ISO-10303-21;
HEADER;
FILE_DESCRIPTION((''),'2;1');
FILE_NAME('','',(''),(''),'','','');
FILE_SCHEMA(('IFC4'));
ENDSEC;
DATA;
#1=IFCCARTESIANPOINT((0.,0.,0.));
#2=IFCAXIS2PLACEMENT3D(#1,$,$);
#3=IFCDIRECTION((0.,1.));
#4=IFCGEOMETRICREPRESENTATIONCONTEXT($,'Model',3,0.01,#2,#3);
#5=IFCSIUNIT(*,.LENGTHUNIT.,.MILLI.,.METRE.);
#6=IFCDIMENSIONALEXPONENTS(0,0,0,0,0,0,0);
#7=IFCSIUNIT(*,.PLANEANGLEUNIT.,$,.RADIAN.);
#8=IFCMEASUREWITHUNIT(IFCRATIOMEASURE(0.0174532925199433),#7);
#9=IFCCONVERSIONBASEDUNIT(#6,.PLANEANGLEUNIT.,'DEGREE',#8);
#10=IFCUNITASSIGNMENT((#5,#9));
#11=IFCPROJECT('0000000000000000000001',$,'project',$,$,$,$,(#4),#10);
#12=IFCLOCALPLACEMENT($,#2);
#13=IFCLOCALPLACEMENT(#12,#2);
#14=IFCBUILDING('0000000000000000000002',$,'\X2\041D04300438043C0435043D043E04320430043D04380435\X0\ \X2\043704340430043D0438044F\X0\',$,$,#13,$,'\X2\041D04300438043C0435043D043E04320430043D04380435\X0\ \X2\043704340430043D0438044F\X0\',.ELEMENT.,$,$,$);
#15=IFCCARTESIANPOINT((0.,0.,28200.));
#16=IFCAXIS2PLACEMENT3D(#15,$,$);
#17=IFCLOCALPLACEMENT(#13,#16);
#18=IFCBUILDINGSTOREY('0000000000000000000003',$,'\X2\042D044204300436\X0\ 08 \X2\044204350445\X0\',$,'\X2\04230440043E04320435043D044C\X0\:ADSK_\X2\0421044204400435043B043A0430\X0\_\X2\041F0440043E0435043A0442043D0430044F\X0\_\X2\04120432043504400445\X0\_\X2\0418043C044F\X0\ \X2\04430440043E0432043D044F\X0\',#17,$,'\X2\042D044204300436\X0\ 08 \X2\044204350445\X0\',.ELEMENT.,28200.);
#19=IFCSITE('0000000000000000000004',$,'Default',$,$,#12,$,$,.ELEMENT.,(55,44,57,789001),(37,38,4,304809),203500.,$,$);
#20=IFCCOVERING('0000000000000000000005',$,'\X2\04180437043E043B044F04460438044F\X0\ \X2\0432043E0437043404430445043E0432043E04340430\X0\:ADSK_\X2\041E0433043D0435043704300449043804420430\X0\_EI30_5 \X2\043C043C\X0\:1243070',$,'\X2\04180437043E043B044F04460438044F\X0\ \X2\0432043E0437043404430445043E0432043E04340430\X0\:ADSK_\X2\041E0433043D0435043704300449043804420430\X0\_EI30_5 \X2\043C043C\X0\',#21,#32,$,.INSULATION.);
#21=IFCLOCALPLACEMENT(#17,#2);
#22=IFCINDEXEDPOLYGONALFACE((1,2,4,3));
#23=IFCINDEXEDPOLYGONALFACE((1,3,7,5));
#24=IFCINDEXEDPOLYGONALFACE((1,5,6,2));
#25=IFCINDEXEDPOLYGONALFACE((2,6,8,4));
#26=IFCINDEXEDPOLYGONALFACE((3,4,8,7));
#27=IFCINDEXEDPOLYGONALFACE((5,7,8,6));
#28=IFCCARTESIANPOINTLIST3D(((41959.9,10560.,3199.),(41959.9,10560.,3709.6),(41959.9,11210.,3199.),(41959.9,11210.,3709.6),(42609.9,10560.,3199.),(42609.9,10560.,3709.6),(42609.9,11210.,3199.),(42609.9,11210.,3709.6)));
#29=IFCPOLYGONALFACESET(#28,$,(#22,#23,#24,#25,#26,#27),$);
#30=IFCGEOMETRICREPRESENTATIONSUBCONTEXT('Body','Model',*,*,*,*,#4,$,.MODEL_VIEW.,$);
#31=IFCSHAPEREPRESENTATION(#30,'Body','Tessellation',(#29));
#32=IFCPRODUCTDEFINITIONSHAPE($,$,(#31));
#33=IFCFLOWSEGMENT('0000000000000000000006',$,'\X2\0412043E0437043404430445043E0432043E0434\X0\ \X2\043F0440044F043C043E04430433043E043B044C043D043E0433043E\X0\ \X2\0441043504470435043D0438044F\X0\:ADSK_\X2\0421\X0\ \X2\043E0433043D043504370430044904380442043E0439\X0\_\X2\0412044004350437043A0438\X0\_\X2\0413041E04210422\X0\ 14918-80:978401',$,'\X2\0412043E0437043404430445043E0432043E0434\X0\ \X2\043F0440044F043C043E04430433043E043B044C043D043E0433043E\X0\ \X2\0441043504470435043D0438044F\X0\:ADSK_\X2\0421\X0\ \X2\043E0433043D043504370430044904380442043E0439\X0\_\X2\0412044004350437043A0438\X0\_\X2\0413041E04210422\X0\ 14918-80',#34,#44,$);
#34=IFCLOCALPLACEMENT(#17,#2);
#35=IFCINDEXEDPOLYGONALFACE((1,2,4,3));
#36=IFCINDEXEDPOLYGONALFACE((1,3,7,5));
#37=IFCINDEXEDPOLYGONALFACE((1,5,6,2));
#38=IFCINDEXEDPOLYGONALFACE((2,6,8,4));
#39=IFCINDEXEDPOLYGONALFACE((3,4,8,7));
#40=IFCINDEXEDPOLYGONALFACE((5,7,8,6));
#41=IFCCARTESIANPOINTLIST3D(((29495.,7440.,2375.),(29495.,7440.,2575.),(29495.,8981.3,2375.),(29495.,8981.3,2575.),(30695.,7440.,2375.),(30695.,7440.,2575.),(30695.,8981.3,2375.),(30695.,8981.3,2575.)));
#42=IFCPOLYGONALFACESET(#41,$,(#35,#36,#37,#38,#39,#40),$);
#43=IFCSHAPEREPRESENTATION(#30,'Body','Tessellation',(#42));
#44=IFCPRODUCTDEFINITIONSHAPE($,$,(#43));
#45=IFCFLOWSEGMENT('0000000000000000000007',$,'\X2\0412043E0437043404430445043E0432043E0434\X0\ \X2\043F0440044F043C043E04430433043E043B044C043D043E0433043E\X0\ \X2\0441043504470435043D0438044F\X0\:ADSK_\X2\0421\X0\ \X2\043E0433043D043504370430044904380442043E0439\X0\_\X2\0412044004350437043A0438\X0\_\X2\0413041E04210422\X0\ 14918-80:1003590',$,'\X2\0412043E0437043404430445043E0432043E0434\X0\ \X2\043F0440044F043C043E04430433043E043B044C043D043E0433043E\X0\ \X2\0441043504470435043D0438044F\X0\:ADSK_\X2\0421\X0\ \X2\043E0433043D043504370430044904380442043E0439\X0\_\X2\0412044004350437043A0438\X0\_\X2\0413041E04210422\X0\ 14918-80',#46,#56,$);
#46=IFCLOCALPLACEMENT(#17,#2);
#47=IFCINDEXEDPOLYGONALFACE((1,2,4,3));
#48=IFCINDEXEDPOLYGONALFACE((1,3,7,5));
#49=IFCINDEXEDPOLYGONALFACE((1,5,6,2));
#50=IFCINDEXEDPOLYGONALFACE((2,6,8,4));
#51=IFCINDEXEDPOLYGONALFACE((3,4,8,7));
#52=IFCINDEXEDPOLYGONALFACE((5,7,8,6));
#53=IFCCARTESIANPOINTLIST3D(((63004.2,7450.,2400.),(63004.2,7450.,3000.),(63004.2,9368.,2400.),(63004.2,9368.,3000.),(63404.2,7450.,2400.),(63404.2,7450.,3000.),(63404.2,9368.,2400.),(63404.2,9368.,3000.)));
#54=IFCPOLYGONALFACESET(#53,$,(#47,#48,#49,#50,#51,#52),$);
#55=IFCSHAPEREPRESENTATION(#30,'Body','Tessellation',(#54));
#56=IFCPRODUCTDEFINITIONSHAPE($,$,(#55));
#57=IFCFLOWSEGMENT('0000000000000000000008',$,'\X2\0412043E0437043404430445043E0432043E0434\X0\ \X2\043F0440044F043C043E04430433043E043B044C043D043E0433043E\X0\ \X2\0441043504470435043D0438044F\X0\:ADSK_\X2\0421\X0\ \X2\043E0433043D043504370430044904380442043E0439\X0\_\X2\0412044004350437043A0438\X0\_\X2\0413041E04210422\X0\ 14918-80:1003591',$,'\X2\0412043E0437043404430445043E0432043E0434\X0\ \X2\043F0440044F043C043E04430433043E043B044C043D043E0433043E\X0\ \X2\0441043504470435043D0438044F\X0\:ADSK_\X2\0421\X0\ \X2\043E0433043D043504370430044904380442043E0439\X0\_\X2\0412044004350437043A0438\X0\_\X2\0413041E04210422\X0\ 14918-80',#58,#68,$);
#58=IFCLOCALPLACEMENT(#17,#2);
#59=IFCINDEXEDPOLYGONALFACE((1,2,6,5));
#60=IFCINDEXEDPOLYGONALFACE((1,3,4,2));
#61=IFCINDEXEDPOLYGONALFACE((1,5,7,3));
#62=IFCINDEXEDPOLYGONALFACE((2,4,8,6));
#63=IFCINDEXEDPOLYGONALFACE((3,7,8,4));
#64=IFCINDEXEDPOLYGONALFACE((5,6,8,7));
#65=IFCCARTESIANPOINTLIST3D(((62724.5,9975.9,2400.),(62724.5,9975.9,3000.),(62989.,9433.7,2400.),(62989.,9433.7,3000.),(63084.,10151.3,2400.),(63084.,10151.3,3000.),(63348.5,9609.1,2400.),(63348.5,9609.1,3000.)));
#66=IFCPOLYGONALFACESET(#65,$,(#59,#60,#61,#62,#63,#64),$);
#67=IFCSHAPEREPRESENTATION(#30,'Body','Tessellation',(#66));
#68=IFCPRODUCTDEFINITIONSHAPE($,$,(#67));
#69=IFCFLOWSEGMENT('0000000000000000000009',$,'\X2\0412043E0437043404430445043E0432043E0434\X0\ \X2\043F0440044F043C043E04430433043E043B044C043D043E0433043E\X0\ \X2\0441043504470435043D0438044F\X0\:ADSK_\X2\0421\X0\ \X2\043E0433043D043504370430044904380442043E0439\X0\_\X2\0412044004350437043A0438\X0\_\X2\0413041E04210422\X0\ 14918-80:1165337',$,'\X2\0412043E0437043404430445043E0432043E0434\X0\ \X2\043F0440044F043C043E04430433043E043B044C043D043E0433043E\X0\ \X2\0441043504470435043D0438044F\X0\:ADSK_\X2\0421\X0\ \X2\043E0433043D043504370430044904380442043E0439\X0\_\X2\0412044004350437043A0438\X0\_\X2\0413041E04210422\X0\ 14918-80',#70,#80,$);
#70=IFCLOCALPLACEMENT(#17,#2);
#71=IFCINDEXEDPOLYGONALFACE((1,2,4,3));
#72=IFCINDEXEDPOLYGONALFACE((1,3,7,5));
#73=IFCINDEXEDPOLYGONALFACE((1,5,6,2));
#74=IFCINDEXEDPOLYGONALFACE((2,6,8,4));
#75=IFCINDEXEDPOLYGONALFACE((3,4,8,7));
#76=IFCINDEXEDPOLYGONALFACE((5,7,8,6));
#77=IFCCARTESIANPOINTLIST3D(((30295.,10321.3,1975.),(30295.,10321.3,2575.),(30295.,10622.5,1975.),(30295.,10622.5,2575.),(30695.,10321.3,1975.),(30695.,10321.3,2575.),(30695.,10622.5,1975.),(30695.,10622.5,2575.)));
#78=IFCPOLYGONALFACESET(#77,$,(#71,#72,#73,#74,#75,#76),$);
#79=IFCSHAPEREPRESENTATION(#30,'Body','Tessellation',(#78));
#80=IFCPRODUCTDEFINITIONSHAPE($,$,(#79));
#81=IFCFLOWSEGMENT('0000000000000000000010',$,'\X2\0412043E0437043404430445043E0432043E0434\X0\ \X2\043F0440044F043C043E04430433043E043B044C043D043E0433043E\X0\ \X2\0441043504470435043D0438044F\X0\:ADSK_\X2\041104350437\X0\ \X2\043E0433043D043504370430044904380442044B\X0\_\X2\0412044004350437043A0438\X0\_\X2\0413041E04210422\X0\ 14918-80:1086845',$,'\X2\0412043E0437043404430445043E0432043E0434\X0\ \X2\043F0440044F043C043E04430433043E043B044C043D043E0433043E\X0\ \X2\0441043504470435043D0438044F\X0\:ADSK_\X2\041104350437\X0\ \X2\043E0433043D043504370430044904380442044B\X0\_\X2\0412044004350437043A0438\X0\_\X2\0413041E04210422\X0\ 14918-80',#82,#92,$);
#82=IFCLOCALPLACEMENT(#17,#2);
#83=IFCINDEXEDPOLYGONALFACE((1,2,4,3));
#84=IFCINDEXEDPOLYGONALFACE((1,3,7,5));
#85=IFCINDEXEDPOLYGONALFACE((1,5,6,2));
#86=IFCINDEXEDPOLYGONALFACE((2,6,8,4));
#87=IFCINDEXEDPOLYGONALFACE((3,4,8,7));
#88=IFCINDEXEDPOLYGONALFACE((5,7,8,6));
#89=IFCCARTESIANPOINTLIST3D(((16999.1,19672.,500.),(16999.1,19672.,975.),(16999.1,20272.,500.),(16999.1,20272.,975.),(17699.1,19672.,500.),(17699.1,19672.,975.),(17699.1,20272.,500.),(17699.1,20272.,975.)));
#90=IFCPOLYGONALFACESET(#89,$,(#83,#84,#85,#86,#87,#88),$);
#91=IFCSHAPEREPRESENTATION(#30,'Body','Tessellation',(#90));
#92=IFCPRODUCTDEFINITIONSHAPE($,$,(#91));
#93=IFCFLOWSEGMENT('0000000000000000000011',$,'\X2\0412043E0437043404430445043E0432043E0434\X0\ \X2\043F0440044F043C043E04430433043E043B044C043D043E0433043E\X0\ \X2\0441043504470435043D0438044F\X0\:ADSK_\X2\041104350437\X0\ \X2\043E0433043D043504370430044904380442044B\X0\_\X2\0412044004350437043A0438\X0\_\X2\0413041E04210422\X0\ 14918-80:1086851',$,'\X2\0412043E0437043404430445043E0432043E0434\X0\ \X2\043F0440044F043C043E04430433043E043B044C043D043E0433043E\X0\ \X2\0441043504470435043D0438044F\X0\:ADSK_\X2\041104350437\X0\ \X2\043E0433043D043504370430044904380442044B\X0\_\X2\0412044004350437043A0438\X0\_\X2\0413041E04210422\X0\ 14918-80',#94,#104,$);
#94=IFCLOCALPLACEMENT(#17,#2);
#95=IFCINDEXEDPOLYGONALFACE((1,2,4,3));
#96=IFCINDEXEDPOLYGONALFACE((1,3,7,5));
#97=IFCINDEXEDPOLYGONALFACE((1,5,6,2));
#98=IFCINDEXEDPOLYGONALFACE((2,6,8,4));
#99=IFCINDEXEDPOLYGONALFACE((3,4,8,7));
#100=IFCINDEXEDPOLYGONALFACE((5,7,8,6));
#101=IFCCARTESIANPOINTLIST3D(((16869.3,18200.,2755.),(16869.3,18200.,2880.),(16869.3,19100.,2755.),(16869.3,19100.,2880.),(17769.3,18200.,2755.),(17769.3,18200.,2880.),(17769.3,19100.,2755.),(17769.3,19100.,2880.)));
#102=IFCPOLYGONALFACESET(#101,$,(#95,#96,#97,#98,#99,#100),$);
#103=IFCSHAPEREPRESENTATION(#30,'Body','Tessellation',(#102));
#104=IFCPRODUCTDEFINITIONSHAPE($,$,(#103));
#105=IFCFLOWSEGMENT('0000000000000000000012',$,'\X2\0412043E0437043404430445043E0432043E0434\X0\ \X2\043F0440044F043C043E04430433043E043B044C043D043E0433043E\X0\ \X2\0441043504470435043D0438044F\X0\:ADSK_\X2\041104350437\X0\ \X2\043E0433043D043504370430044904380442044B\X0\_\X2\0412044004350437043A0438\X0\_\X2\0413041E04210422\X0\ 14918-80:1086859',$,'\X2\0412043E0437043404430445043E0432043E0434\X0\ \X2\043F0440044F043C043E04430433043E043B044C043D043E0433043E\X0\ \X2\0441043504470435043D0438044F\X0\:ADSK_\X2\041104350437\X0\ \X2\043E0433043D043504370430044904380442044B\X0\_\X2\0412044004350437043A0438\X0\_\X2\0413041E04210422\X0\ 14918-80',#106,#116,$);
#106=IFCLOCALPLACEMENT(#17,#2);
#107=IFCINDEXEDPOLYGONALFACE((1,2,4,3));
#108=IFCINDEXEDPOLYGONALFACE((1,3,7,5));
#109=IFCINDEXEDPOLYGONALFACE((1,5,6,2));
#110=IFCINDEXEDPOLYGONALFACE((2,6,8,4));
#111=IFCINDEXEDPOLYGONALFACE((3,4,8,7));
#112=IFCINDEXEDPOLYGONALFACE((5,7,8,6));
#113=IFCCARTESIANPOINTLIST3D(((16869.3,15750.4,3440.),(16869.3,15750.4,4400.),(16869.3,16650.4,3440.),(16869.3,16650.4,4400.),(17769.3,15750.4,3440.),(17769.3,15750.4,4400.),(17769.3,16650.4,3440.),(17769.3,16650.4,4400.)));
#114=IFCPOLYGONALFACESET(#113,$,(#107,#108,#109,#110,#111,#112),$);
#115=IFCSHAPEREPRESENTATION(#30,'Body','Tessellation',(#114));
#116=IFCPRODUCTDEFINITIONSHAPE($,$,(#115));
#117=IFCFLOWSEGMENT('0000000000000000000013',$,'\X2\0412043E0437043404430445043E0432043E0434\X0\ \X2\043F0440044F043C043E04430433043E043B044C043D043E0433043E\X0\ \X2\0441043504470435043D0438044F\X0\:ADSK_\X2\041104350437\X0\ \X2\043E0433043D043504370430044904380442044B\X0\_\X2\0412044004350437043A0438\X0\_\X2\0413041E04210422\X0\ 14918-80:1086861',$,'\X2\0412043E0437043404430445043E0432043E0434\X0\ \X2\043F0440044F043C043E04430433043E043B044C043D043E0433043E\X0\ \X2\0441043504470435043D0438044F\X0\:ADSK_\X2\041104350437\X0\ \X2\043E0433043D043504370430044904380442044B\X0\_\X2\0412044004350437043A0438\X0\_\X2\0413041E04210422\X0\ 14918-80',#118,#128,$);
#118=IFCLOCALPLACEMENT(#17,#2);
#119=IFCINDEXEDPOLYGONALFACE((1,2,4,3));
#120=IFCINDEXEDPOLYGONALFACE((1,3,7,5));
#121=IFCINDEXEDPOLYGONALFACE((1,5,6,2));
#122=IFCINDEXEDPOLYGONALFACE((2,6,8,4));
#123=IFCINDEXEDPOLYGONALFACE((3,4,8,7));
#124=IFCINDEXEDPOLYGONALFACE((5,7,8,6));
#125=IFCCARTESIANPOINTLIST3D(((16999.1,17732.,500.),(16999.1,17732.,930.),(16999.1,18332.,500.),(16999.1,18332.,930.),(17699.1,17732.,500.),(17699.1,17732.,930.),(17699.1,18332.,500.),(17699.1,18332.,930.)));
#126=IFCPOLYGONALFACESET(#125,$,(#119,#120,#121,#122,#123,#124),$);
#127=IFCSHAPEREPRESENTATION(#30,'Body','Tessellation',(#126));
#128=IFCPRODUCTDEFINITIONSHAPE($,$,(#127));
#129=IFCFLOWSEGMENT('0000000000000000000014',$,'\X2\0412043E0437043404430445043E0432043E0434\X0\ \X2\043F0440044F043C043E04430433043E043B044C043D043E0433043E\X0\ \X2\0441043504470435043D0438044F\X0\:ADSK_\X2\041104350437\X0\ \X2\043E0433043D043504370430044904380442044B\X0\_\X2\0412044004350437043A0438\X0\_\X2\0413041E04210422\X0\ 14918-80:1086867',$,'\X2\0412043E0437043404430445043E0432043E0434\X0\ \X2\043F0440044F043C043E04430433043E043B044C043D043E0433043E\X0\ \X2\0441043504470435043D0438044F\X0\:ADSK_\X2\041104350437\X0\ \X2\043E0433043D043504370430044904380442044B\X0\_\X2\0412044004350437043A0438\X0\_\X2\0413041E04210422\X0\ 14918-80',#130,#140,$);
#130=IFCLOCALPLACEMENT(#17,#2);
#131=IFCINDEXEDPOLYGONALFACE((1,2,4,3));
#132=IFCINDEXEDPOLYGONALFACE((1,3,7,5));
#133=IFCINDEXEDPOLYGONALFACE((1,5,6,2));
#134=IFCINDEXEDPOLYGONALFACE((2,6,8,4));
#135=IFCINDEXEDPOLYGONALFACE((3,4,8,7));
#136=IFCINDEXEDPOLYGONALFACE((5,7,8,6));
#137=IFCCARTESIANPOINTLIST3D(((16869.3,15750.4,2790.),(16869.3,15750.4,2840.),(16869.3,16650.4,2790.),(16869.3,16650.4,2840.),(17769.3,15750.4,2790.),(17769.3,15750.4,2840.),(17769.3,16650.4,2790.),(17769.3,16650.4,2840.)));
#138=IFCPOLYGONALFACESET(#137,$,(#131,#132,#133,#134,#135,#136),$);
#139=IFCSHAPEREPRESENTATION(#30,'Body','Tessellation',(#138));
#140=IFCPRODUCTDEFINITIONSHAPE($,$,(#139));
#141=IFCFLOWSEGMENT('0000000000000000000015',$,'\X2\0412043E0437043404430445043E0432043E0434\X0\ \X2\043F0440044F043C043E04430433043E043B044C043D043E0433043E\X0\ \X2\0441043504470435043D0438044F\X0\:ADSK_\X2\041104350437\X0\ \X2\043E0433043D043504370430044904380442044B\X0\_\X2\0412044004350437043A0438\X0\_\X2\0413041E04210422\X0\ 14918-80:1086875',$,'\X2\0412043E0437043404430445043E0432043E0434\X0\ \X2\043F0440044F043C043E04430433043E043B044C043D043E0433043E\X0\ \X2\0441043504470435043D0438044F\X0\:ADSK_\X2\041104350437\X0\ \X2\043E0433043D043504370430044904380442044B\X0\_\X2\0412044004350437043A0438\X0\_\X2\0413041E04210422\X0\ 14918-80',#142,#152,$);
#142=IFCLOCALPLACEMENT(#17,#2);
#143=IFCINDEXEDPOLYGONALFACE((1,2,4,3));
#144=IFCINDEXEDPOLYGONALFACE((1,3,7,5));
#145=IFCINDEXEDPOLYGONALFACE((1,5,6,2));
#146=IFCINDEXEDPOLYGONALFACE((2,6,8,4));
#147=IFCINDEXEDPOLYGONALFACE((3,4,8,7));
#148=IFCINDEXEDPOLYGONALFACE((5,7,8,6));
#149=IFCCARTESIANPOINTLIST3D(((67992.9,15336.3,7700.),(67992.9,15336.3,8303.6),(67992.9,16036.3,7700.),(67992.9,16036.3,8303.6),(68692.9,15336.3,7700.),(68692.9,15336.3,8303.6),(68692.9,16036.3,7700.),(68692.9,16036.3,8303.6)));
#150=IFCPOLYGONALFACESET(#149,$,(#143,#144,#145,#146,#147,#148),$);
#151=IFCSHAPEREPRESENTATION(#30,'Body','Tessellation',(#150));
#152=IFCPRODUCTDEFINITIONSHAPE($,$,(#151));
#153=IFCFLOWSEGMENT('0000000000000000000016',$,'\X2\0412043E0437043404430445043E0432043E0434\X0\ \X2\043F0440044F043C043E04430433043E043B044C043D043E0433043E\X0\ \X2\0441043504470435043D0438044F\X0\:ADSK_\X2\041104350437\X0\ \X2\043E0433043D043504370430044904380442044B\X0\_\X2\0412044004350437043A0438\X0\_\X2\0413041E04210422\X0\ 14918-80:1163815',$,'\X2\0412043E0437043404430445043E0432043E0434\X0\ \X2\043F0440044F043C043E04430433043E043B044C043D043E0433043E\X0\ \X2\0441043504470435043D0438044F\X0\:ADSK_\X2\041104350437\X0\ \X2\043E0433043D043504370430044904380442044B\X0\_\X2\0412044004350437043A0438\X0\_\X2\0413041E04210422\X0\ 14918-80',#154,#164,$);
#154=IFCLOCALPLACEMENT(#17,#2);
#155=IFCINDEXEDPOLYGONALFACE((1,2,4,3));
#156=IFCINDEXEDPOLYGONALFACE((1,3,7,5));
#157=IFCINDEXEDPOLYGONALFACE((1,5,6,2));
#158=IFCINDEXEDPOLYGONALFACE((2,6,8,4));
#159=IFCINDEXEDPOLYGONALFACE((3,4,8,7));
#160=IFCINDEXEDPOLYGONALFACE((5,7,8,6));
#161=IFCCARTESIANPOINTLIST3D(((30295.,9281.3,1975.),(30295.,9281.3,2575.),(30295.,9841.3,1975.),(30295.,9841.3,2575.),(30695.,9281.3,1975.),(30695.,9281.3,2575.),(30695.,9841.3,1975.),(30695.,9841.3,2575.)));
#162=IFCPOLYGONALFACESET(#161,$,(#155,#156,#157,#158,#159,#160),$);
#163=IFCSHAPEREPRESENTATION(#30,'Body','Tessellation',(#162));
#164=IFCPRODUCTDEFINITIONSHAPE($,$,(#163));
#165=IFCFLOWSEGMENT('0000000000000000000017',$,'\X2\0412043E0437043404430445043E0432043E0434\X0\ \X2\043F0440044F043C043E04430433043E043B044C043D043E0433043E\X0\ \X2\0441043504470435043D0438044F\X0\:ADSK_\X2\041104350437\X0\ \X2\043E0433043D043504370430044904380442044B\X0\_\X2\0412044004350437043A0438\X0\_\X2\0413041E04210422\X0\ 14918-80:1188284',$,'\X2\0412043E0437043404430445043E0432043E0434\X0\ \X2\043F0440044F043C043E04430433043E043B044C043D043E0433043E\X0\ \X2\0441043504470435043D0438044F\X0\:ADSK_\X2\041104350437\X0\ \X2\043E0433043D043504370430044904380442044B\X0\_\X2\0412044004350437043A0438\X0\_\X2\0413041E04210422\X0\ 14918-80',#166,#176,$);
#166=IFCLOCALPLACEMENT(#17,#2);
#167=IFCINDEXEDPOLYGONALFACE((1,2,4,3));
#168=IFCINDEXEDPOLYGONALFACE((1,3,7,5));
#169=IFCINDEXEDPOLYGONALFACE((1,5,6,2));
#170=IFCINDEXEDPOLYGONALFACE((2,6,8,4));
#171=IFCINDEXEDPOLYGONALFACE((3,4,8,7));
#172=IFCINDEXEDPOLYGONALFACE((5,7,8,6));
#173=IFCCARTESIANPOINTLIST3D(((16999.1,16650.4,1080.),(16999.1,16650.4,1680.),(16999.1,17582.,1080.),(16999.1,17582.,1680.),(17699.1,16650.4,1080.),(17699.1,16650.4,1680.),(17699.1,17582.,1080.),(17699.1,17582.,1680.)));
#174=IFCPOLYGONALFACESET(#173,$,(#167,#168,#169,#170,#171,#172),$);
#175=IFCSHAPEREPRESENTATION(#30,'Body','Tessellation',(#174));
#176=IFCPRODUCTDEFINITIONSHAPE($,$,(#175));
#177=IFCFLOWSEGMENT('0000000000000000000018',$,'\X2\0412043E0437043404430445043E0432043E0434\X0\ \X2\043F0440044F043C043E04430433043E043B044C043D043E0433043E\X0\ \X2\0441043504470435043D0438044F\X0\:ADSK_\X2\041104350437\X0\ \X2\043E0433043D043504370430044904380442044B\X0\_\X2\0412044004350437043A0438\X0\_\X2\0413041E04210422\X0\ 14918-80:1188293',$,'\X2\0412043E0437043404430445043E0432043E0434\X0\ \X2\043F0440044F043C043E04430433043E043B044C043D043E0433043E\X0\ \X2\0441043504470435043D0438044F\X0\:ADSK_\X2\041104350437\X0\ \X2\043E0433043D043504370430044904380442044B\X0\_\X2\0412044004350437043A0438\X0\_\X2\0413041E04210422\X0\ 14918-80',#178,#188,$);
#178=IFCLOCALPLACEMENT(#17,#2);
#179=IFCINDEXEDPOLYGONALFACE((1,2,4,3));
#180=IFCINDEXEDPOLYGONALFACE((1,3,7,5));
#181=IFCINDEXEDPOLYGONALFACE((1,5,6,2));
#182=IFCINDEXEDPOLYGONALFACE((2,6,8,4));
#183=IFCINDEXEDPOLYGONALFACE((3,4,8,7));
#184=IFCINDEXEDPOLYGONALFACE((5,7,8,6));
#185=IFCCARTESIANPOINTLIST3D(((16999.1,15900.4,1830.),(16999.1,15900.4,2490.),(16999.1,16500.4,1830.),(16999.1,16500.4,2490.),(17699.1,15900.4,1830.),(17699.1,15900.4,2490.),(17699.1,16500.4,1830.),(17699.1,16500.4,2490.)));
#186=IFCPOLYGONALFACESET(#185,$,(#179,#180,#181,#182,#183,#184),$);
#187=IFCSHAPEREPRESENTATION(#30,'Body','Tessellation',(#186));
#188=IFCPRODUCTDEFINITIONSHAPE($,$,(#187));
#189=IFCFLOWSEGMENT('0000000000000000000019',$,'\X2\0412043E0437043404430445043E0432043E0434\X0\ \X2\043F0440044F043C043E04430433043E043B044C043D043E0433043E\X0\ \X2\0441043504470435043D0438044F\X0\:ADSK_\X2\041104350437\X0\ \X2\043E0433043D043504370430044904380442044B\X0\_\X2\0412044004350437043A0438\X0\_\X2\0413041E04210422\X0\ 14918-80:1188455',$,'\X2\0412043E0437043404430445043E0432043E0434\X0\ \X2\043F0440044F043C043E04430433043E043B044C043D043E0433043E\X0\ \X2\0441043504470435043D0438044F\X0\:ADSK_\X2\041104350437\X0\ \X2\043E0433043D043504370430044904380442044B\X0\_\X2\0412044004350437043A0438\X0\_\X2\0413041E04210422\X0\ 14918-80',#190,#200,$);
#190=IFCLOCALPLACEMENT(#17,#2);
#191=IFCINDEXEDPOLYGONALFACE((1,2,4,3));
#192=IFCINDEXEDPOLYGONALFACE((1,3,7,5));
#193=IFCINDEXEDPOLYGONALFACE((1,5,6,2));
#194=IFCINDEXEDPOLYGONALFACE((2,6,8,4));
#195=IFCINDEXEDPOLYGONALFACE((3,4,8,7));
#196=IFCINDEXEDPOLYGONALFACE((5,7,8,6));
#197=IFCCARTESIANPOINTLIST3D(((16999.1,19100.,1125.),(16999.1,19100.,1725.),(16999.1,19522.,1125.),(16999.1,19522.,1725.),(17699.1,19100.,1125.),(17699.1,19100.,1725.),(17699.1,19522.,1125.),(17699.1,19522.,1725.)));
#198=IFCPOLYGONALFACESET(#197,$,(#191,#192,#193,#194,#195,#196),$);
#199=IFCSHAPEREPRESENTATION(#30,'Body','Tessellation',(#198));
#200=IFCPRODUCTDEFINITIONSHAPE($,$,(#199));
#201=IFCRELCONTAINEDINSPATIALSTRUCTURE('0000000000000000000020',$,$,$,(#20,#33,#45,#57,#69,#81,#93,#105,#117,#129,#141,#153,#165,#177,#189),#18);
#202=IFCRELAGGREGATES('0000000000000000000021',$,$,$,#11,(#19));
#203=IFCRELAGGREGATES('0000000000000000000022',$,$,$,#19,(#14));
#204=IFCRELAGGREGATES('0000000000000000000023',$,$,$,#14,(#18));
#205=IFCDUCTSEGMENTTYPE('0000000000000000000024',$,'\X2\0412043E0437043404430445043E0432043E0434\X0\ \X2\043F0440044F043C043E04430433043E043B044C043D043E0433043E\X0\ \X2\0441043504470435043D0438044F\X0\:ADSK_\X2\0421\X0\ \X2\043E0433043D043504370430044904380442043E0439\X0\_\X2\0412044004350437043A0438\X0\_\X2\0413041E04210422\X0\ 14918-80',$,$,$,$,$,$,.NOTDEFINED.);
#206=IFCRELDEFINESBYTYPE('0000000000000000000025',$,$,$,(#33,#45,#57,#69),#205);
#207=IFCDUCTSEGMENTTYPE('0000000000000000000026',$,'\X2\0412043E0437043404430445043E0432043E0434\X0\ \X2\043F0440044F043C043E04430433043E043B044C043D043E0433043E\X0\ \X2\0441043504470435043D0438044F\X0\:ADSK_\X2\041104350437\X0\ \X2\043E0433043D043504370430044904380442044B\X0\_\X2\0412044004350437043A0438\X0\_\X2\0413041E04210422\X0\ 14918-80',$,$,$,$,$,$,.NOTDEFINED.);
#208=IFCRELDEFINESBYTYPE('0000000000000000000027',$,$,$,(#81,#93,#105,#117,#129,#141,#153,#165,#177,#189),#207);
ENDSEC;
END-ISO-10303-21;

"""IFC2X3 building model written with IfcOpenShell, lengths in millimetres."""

from ifc_helpers import new_model, entity, si_unit, converted_unit, direction, frame, origin, origin_2d_with_axis, place, context, subcontext, project, spatial, rectangle, extrude, type_object, element, save


model = new_model("IFC2X3")

# Units and contexts
model_context = context("Model", 3, precision=0.01, world=origin(), true_north=direction((0.0, 1.0)))
body_context = subcontext(model_context, "Body", "Model", "MODEL_VIEW")
ifc_project = project(units=[si_unit("LENGTHUNIT", "METRE", prefix="MILLI"), converted_unit("PLANEANGLEUNIT", "DEGREE", entity("IfcRatioMeasure", 0.0174532925199433), si_unit("PLANEANGLEUNIT", "RADIAN"), dimensions=[0, 0, 0, 0, 0, 0, 0])], contexts=[model_context])

# Site, building, storey
site_placement = place(None, origin())
site = spatial("IfcSite", under=ifc_project, at=site_placement, Name="Default", CompositionType="ELEMENT", RefLatitude=(55, 44, 57, 789001), RefLongitude=(37, 38, 4, 304809), RefElevation=203500.0)
building_placement = place(site_placement, origin())
building = spatial("IfcBuilding", under=site, at=building_placement, Name="Наименование здания", LongName="Наименование здания", CompositionType="ELEMENT")
storey_placement = place(building_placement, frame((0.0, 0.0, 28200.0)))
storey = spatial("IfcBuildingStorey", under=building, at=storey_placement, Name="Этаж 08 тех", ObjectType="Уровень:ADSK_Стрелка_Проектная_Вверх_Имя уровня", LongName="Этаж 08 тех", CompositionType="ELEMENT", Elevation=28200.0)

# Covering
covering_1_placement = place(storey_placement, frame((41959.9, 10560.0, 3199.0)))
element("IfcCovering", 1, at=covering_1_placement, inside=storey, Name="Изоляция воздуховода:ADSK_Огнезащита_EI30_5 мм:1243070", ObjectType="Изоляция воздуховода:ADSK_Огнезащита_EI30_5 мм", PredefinedType="INSULATION", context=body_context, shape_type="SweptSolid", body=[
    extrude(rectangle(XDim=650.0, YDim=650.0, at=origin_2d_with_axis()), frame((325.0, 325.0, 0.0), z_axis=(0.0, 0.0, 1.0), x_axis=(-1.0, 0.0, 0.0)), (0.0, 0.0, 1.0), 510.6),
])

# Flow segments
duct_segment_type_1 = type_object("IfcDuctSegmentType", Name="Воздуховод прямоугольного сечения:ADSK_С огнезащитой_Врезки_ГОСТ 14918-80", PredefinedType="NOTDEFINED")
flow_segment_1_placement = place(storey_placement, frame((29495.0, 7440.0, 2375.0)))
element("IfcFlowSegment", 2, at=flow_segment_1_placement, inside=storey, type_object=duct_segment_type_1, Name="Воздуховод прямоугольного сечения:ADSK_С огнезащитой_Врезки_ГОСТ 14918-80:978401", ObjectType="Воздуховод прямоугольного сечения:ADSK_С огнезащитой_Врезки_ГОСТ 14918-80", context=body_context, shape_type="SweptSolid", body=[
    extrude(rectangle(XDim=1541.3, YDim=1200.0, at=origin_2d_with_axis()), frame((600.0, 770.6, 0.0), z_axis=(0.0, 0.0, 1.0), x_axis=(0.0, 1.0, 0.0)), (0.0, 0.0, 1.0), 200.0),
])
flow_segment_2_placement = place(storey_placement, frame((63004.2, 7450.0, 2400.0)))
element("IfcFlowSegment", 3, at=flow_segment_2_placement, inside=storey, type_object=duct_segment_type_1, Name="Воздуховод прямоугольного сечения:ADSK_С огнезащитой_Врезки_ГОСТ 14918-80:1003590", ObjectType="Воздуховод прямоугольного сечения:ADSK_С огнезащитой_Врезки_ГОСТ 14918-80", context=body_context, shape_type="SweptSolid", body=[
    extrude(rectangle(XDim=1918.0, YDim=400.0, at=origin_2d_with_axis()), frame((200.0, 959.0, 0.0), z_axis=(0.0, 0.0, 1.0), x_axis=(0.0, -1.0, 0.0)), (0.0, 0.0, 1.0), 600.0),
])
flow_segment_3_placement = place(storey_placement, frame((62724.5, 9433.7, 2400.0)))
element("IfcFlowSegment", 4, at=flow_segment_3_placement, inside=storey, type_object=duct_segment_type_1, Name="Воздуховод прямоугольного сечения:ADSK_С огнезащитой_Врезки_ГОСТ 14918-80:1003591", ObjectType="Воздуховод прямоугольного сечения:ADSK_С огнезащитой_Врезки_ГОСТ 14918-80", context=body_context, shape_type="SweptSolid", body=[
    extrude(rectangle(XDim=603.3, YDim=400.0, at=origin_2d_with_axis()), frame((312.0, 358.8, 0.0), z_axis=(0.0, 0.0, 1.0), x_axis=(-0.438371, 0.898794, 0.0)), (0.0, 0.0, 1.0), 600.0),
])
flow_segment_4_placement = place(storey_placement, frame((30295.0, 10321.3, 1975.0)))
element("IfcFlowSegment", 5, at=flow_segment_4_placement, inside=storey, type_object=duct_segment_type_1, Name="Воздуховод прямоугольного сечения:ADSK_С огнезащитой_Врезки_ГОСТ 14918-80:1165337", ObjectType="Воздуховод прямоугольного сечения:ADSK_С огнезащитой_Врезки_ГОСТ 14918-80", context=body_context, shape_type="SweptSolid", body=[
    extrude(rectangle(XDim=301.2, YDim=400.0, at=origin_2d_with_axis()), frame((200.0, 150.6, 0.0), z_axis=(0.0, 0.0, 1.0), x_axis=(0.0, 1.0, 0.0)), (0.0, 0.0, 1.0), 600.0),
])
duct_segment_type_2 = type_object("IfcDuctSegmentType", Name="Воздуховод прямоугольного сечения:ADSK_Без огнезащиты_Врезки_ГОСТ 14918-80", PredefinedType="NOTDEFINED")
flow_segment_5_placement = place(storey_placement, frame((16999.1, 19672.0, 500.0)))
element("IfcFlowSegment", 6, at=flow_segment_5_placement, inside=storey, type_object=duct_segment_type_2, Name="Воздуховод прямоугольного сечения:ADSK_Без огнезащиты_Врезки_ГОСТ 14918-80:1086845", ObjectType="Воздуховод прямоугольного сечения:ADSK_Без огнезащиты_Врезки_ГОСТ 14918-80", context=body_context, shape_type="SweptSolid", body=[
    extrude(rectangle(XDim=700.0, YDim=600.0, at=origin_2d_with_axis()), frame((350.0, 300.0, 0.0), z_axis=(0.0, 0.0, 1.0), x_axis=(-1.0, 0.0, 0.0)), (0.0, 0.0, 1.0), 475.0),
])
flow_segment_6_placement = place(storey_placement, frame((16869.3, 18200.0, 2755.0)))
element("IfcFlowSegment", 7, at=flow_segment_6_placement, inside=storey, type_object=duct_segment_type_2, Name="Воздуховод прямоугольного сечения:ADSK_Без огнезащиты_Врезки_ГОСТ 14918-80:1086851", ObjectType="Воздуховод прямоугольного сечения:ADSK_Без огнезащиты_Врезки_ГОСТ 14918-80", context=body_context, shape_type="SweptSolid", body=[
    extrude(rectangle(XDim=900.0, YDim=900.0, at=origin_2d_with_axis()), frame((450.0, 450.0, 0.0)), (0.0, 0.0, 1.0), 125.0),
])
flow_segment_7_placement = place(storey_placement, frame((16869.3, 15750.4, 3440.0)))
element("IfcFlowSegment", 8, at=flow_segment_7_placement, inside=storey, type_object=duct_segment_type_2, Name="Воздуховод прямоугольного сечения:ADSK_Без огнезащиты_Врезки_ГОСТ 14918-80:1086859", ObjectType="Воздуховод прямоугольного сечения:ADSK_Без огнезащиты_Врезки_ГОСТ 14918-80", context=body_context, shape_type="SweptSolid", body=[
    extrude(rectangle(XDim=900.0, YDim=900.0, at=origin_2d_with_axis()), frame((450.0, 450.0, 0.0)), (0.0, 0.0, 1.0), 960.0),
])
flow_segment_8_placement = place(storey_placement, frame((16999.1, 17732.0, 500.0)))
element("IfcFlowSegment", 9, at=flow_segment_8_placement, inside=storey, type_object=duct_segment_type_2, Name="Воздуховод прямоугольного сечения:ADSK_Без огнезащиты_Врезки_ГОСТ 14918-80:1086861", ObjectType="Воздуховод прямоугольного сечения:ADSK_Без огнезащиты_Врезки_ГОСТ 14918-80", context=body_context, shape_type="SweptSolid", body=[
    extrude(rectangle(XDim=700.0, YDim=600.0, at=origin_2d_with_axis()), frame((350.0, 300.0, 0.0)), (0.0, 0.0, 1.0), 430.0),
])
flow_segment_9_placement = place(storey_placement, frame((16869.3, 15750.4, 2790.0)))
element("IfcFlowSegment", 10, at=flow_segment_9_placement, inside=storey, type_object=duct_segment_type_2, Name="Воздуховод прямоугольного сечения:ADSK_Без огнезащиты_Врезки_ГОСТ 14918-80:1086867", ObjectType="Воздуховод прямоугольного сечения:ADSK_Без огнезащиты_Врезки_ГОСТ 14918-80", context=body_context, shape_type="SweptSolid", body=[
    extrude(rectangle(XDim=900.0, YDim=900.0, at=origin_2d_with_axis()), frame((450.0, 450.0, 0.0)), (0.0, 0.0, 1.0), 50.0),
])
flow_segment_10_placement = place(storey_placement, frame((67992.9, 15336.3, 7700.0)))
element("IfcFlowSegment", 11, at=flow_segment_10_placement, inside=storey, type_object=duct_segment_type_2, Name="Воздуховод прямоугольного сечения:ADSK_Без огнезащиты_Врезки_ГОСТ 14918-80:1086875", ObjectType="Воздуховод прямоугольного сечения:ADSK_Без огнезащиты_Врезки_ГОСТ 14918-80", context=body_context, shape_type="SweptSolid", body=[
    extrude(rectangle(XDim=700.0, YDim=700.0, at=origin_2d_with_axis()), frame((350.0, 350.0, 0.0)), (0.0, 0.0, 1.0), 603.6),
])
flow_segment_11_placement = place(storey_placement, frame((30295.0, 9281.3, 1975.0)))
element("IfcFlowSegment", 12, at=flow_segment_11_placement, inside=storey, type_object=duct_segment_type_2, Name="Воздуховод прямоугольного сечения:ADSK_Без огнезащиты_Врезки_ГОСТ 14918-80:1163815", ObjectType="Воздуховод прямоугольного сечения:ADSK_Без огнезащиты_Врезки_ГОСТ 14918-80", context=body_context, shape_type="SweptSolid", body=[
    extrude(rectangle(XDim=560.0, YDim=400.0, at=origin_2d_with_axis()), frame((200.0, 280.0, 0.0), z_axis=(0.0, 0.0, 1.0), x_axis=(0.0, -1.0, 0.0)), (0.0, 0.0, 1.0), 600.0),
])
flow_segment_12_placement = place(storey_placement, frame((16999.1, 16650.4, 1080.0)))
element("IfcFlowSegment", 13, at=flow_segment_12_placement, inside=storey, type_object=duct_segment_type_2, Name="Воздуховод прямоугольного сечения:ADSK_Без огнезащиты_Врезки_ГОСТ 14918-80:1188284", ObjectType="Воздуховод прямоугольного сечения:ADSK_Без огнезащиты_Врезки_ГОСТ 14918-80", context=body_context, shape_type="SweptSolid", body=[
    extrude(rectangle(XDim=931.6, YDim=700.0, at=origin_2d_with_axis()), frame((350.0, 465.8, 0.0), z_axis=(0.0, 0.0, 1.0), x_axis=(0.0, -1.0, 0.0)), (0.0, 0.0, 1.0), 600.0),
])
flow_segment_13_placement = place(storey_placement, frame((16999.1, 15900.4, 1830.0)))
element("IfcFlowSegment", 14, at=flow_segment_13_placement, inside=storey, type_object=duct_segment_type_2, Name="Воздуховод прямоугольного сечения:ADSK_Без огнезащиты_Врезки_ГОСТ 14918-80:1188293", ObjectType="Воздуховод прямоугольного сечения:ADSK_Без огнезащиты_Врезки_ГОСТ 14918-80", context=body_context, shape_type="SweptSolid", body=[
    extrude(rectangle(XDim=700.0, YDim=600.0, at=origin_2d_with_axis()), frame((350.0, 300.0, 0.0)), (0.0, 0.0, 1.0), 660.0),
])
flow_segment_14_placement = place(storey_placement, frame((16999.1, 19100.0, 1125.0)))
element("IfcFlowSegment", 15, at=flow_segment_14_placement, inside=storey, type_object=duct_segment_type_2, Name="Воздуховод прямоугольного сечения:ADSK_Без огнезащиты_Врезки_ГОСТ 14918-80:1188455", ObjectType="Воздуховод прямоугольного сечения:ADSK_Без огнезащиты_Врезки_ГОСТ 14918-80", context=body_context, shape_type="SweptSolid", body=[
    extrude(rectangle(XDim=422.0, YDim=700.0, at=origin_2d_with_axis()), frame((350.0, 211.0, 0.0), z_axis=(0.0, 0.0, 1.0), x_axis=(0.0, -1.0, 0.0)), (0.0, 0.0, 1.0), 600.0),
])

save(model, "model.ifc")
